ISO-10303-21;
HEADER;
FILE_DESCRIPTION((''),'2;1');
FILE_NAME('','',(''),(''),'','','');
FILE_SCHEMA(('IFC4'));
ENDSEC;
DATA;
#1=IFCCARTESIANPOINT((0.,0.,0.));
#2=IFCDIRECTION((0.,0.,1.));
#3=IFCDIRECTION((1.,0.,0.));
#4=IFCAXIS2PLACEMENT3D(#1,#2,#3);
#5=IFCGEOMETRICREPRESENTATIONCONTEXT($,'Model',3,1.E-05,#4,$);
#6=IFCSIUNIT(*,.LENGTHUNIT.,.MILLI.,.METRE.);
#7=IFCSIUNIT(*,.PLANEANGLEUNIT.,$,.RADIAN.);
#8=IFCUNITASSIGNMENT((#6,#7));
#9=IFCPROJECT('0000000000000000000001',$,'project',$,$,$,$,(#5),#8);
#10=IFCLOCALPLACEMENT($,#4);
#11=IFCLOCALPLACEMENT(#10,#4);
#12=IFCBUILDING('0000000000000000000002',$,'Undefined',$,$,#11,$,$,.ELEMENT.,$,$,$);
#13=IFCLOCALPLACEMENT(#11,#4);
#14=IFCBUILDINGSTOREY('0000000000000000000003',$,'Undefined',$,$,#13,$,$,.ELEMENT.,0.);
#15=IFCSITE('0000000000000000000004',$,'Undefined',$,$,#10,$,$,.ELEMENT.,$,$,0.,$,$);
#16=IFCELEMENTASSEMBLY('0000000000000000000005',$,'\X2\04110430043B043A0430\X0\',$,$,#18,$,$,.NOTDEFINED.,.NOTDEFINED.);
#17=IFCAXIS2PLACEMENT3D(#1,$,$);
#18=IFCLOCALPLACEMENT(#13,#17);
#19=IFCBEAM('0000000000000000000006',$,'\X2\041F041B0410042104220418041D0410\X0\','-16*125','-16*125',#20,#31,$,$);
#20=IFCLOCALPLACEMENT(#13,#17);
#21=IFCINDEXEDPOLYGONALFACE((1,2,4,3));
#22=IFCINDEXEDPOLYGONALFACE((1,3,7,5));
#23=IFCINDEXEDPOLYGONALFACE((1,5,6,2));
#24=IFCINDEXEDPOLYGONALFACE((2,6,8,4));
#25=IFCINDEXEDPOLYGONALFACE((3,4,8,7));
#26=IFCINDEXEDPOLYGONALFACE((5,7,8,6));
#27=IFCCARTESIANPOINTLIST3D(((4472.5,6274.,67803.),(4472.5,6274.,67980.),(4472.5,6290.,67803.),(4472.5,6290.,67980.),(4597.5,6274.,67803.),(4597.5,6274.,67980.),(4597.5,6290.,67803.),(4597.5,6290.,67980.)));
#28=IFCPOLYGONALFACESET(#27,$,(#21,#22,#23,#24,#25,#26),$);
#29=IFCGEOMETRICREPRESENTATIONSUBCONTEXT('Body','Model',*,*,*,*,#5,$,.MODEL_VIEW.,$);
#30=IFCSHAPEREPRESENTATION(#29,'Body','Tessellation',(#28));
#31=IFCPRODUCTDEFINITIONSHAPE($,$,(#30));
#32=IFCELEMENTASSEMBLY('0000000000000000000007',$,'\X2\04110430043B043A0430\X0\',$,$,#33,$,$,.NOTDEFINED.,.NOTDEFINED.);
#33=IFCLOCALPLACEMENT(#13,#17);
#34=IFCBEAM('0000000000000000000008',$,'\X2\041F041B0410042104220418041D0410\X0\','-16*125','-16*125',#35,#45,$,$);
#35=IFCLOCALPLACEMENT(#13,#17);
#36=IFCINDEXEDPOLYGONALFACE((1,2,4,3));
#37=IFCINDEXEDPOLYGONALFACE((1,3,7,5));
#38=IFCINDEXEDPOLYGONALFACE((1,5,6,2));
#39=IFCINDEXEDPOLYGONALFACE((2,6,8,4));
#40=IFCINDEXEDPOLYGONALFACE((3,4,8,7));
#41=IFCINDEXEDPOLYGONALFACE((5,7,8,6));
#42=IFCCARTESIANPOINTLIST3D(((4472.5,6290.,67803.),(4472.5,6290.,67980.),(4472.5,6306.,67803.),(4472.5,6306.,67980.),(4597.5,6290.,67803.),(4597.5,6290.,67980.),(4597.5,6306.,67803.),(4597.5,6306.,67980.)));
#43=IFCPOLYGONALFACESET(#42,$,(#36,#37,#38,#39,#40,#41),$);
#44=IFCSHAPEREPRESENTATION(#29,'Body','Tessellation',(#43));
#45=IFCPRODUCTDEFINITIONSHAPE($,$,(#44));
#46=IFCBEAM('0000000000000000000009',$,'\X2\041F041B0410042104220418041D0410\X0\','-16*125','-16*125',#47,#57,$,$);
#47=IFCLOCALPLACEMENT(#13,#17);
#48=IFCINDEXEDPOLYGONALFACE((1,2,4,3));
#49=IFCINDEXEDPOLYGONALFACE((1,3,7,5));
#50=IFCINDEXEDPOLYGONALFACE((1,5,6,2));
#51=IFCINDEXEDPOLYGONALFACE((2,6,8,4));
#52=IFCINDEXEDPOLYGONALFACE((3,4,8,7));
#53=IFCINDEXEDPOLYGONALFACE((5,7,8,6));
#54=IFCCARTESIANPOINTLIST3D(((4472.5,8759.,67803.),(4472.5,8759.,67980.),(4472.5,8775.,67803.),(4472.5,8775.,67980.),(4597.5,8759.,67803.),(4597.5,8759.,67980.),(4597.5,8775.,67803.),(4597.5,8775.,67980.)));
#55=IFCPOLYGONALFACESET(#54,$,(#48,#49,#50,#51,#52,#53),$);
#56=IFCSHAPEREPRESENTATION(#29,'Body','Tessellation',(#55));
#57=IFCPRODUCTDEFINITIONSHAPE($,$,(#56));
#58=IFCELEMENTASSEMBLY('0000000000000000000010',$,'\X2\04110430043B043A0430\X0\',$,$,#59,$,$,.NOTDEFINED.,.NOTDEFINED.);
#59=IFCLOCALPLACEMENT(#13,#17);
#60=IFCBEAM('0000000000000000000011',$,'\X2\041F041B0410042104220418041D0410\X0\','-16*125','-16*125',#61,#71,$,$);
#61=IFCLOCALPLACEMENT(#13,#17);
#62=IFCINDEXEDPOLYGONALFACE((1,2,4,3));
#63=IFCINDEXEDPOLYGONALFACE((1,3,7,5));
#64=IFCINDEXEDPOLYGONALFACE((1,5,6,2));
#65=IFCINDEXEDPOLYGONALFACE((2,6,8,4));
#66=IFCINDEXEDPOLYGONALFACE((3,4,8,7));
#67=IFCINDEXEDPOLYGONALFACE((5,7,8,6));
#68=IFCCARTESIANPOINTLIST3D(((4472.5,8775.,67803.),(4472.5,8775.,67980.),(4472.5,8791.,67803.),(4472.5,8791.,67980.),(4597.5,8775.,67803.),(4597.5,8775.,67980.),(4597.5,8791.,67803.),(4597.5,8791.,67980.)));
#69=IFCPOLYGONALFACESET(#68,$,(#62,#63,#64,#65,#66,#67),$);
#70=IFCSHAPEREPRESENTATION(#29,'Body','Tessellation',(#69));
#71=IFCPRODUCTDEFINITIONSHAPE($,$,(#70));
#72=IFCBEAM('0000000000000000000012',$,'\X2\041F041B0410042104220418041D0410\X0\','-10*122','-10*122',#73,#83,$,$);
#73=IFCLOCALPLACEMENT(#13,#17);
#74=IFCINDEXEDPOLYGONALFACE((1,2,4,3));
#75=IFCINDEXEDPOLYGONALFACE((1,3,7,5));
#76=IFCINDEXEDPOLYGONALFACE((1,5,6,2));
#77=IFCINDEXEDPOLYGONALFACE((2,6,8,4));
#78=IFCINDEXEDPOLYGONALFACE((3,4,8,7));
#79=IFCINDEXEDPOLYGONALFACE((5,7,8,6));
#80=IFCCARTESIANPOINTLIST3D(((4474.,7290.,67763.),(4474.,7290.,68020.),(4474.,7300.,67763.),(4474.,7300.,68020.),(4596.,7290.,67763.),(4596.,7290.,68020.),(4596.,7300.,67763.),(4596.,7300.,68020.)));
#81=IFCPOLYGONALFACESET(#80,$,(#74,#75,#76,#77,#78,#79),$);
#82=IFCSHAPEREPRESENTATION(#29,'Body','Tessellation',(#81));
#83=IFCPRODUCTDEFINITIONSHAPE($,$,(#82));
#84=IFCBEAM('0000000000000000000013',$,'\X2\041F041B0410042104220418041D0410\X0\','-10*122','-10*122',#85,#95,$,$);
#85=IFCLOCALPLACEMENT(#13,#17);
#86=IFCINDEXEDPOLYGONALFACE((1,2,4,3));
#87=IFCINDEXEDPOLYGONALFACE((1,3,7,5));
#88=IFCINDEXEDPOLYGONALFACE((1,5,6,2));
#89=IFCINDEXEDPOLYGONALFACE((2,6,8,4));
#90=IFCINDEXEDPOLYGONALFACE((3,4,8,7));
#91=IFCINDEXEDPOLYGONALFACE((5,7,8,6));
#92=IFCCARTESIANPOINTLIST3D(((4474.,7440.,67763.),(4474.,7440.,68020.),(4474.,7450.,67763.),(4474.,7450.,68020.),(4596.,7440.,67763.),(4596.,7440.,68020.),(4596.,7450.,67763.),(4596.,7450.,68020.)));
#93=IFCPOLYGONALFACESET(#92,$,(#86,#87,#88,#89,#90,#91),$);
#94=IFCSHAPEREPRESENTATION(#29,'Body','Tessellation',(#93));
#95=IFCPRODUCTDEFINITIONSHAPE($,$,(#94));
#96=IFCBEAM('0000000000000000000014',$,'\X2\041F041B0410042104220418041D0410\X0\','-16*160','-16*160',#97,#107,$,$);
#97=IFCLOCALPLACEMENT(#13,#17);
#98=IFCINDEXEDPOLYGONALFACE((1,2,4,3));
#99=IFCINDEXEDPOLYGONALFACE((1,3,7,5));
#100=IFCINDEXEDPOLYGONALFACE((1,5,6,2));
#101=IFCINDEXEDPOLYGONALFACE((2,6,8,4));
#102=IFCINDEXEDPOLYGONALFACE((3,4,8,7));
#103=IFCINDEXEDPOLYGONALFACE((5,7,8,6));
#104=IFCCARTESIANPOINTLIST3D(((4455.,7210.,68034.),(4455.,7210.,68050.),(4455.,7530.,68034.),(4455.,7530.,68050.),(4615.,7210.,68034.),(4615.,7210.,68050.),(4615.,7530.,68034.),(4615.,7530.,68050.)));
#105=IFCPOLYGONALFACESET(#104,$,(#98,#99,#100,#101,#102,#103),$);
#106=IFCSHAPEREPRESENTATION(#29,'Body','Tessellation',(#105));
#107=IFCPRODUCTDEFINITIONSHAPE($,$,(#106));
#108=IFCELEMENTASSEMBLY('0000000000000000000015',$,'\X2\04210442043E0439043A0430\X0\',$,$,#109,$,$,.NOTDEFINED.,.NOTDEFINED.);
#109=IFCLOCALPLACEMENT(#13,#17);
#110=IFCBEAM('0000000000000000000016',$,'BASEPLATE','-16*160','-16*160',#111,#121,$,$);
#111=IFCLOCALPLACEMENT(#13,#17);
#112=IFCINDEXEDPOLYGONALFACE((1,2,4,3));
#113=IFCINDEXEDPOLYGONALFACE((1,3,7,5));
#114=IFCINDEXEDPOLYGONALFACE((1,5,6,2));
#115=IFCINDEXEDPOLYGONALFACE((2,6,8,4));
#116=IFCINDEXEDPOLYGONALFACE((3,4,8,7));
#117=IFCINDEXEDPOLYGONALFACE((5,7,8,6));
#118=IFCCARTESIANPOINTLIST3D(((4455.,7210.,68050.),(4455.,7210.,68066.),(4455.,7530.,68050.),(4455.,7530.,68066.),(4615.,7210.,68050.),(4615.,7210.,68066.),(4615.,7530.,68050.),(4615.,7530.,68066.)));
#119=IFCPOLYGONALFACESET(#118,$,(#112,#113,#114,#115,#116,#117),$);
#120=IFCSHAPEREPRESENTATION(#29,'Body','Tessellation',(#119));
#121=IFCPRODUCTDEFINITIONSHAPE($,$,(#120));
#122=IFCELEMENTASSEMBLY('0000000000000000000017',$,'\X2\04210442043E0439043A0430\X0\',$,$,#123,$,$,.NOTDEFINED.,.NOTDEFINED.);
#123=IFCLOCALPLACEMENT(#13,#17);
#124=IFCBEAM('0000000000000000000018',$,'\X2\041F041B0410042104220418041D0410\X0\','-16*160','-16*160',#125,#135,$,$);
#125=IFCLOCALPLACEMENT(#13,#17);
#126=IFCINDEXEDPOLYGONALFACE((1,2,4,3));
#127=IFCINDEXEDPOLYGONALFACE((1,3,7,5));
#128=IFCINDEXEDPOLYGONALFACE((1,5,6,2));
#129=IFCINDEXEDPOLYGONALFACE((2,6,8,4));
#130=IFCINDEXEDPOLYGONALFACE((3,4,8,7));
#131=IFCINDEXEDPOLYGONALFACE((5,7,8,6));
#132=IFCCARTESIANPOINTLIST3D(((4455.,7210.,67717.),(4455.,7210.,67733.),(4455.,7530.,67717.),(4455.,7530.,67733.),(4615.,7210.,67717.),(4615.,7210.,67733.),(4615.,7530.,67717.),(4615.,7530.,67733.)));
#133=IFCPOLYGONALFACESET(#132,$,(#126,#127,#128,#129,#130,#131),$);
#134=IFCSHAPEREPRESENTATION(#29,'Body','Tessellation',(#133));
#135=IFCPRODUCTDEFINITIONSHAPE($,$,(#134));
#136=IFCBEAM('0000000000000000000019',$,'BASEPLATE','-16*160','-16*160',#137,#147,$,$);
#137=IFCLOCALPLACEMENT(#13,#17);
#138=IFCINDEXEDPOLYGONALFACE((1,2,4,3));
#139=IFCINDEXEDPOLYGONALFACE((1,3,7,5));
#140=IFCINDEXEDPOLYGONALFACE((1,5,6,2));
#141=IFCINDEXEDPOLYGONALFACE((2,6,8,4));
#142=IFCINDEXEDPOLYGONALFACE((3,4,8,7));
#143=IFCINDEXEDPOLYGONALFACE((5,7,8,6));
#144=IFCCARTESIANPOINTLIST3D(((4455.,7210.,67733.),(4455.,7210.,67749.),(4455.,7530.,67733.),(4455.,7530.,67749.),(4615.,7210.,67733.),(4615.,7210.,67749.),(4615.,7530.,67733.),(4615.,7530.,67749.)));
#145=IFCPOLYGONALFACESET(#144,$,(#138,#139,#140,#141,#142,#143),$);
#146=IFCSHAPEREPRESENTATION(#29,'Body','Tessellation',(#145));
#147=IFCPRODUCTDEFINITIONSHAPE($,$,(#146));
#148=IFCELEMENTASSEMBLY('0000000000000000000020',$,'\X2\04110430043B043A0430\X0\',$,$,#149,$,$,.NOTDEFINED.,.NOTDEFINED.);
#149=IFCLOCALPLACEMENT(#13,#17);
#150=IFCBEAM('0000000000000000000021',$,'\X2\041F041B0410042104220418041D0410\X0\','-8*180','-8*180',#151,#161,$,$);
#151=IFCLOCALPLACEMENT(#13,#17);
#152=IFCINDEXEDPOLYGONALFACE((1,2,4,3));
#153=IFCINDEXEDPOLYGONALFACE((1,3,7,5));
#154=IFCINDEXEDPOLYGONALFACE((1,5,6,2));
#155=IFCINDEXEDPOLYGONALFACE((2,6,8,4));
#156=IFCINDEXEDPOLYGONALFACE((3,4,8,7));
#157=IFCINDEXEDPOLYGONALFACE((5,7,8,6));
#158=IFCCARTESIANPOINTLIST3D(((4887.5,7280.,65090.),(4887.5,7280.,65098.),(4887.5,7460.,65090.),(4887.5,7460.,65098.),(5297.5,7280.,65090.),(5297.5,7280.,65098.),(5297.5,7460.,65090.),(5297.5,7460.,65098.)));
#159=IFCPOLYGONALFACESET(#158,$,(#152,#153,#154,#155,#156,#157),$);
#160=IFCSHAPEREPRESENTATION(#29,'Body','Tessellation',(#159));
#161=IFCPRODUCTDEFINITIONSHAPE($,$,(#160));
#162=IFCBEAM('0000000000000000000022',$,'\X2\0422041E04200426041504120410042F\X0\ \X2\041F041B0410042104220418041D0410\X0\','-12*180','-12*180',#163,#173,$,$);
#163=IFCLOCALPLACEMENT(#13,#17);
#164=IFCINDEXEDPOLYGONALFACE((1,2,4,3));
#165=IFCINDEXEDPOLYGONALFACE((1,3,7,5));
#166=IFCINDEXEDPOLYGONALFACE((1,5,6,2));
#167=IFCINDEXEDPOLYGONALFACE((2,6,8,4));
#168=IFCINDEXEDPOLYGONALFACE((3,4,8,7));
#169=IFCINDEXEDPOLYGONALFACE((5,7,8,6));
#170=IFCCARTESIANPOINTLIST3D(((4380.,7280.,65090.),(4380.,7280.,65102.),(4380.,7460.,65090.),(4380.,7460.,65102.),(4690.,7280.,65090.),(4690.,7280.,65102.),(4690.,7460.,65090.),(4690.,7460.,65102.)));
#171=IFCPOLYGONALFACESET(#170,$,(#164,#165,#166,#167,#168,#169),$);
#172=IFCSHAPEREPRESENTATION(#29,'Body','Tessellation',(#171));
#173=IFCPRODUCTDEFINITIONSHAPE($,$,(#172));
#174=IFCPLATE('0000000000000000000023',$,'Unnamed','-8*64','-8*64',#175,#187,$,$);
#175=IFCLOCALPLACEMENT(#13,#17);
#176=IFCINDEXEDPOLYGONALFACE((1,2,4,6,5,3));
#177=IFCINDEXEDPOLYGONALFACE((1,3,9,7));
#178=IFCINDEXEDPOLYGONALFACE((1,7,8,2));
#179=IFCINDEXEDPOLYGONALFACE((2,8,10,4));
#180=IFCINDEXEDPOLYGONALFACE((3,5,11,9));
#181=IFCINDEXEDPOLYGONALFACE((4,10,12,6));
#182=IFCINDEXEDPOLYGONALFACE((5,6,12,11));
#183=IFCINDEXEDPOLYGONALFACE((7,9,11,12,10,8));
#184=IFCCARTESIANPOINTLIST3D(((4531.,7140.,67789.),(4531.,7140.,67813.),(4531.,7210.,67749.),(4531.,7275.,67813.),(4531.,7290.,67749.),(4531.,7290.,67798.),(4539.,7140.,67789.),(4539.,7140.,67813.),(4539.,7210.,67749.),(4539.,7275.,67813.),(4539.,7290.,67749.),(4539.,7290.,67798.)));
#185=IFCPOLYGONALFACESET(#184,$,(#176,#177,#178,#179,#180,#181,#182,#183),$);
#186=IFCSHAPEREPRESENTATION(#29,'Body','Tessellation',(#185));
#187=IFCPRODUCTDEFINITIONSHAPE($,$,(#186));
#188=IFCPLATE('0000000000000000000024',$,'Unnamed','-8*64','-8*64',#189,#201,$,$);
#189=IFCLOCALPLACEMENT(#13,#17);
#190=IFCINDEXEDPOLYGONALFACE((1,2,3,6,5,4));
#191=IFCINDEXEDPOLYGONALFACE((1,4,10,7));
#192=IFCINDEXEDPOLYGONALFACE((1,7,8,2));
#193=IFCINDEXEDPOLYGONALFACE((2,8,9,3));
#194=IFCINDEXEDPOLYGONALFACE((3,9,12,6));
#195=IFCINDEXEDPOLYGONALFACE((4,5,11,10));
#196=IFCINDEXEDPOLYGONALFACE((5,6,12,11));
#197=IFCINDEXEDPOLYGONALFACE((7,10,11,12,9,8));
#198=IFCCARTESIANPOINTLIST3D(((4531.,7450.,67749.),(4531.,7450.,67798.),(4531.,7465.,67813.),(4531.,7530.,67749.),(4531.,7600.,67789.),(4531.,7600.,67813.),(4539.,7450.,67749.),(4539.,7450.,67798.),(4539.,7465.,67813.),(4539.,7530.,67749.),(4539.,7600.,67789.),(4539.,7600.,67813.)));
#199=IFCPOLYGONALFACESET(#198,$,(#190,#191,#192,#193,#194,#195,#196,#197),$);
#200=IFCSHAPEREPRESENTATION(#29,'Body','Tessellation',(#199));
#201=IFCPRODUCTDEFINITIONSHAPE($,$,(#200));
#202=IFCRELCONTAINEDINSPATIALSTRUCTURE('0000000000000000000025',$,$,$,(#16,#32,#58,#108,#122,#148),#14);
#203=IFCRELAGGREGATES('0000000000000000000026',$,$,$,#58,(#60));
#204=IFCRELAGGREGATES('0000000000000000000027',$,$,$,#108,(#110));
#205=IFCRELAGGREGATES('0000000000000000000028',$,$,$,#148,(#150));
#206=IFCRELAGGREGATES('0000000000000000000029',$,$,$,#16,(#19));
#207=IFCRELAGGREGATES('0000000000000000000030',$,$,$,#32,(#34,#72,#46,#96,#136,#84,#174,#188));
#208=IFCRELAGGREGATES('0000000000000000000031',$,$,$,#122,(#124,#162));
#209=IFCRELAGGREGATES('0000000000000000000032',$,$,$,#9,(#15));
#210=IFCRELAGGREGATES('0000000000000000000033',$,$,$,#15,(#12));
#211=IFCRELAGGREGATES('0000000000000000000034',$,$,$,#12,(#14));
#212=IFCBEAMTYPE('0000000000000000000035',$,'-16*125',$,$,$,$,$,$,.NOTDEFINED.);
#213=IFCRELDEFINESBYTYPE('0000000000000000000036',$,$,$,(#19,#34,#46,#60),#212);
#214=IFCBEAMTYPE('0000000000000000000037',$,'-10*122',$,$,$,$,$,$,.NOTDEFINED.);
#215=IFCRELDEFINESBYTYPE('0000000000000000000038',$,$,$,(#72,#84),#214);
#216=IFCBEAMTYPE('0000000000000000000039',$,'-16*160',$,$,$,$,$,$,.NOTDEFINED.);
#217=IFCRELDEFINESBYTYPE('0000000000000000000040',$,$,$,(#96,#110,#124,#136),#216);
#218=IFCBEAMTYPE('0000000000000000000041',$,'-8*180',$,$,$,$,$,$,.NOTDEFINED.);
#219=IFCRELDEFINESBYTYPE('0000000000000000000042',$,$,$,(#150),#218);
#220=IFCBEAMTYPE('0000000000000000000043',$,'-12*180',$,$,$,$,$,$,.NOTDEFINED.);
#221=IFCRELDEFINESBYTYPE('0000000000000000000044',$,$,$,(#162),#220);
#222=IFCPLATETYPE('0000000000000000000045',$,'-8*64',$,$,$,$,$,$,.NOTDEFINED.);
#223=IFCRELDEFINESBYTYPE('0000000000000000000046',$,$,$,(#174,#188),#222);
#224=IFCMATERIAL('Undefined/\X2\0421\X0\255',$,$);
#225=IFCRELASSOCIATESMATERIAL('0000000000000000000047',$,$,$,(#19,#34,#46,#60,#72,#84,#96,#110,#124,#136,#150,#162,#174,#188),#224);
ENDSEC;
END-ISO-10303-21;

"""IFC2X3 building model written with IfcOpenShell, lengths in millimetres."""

from ifc_helpers import new_model, si_unit, frame, origin_with_axes, origin_2d_with_axis, place, context, subcontext, project, spatial, polyline, rectangle, outline, extrude, material, type_object, element, aggregate, save


model = new_model("IFC2X3")

# Units and contexts
model_context = context("Model", 3, precision=1e-05, world=origin_with_axes())
body_context = subcontext(model_context, "Body", "Model", "MODEL_VIEW")
ifc_project = project(units=[si_unit("LENGTHUNIT", "METRE", prefix="MILLI"), si_unit("PLANEANGLEUNIT", "RADIAN")], contexts=[model_context])

# Site, building, storey
site_placement = place(None, origin_with_axes())
site = spatial("IfcSite", under=ifc_project, at=site_placement, Name="Undefined", CompositionType="ELEMENT", RefElevation=0.0)
building_placement = place(site_placement, origin_with_axes())
building = spatial("IfcBuilding", under=site, at=building_placement, Name="Undefined", CompositionType="ELEMENT")
storey_placement = place(building_placement, origin_with_axes())
storey = spatial("IfcBuildingStorey", under=building, at=storey_placement, Name="Undefined", CompositionType="ELEMENT", Elevation=0.0)

# Element assembly, beam
assembly_1_placement = place(storey_placement, origin_with_axes())
assembly_1 = element("IfcElementAssembly", 1, at=assembly_1_placement, inside=storey, Name="Балка", AssemblyPlace="NOTDEFINED", PredefinedType="NOTDEFINED")
ifc_material_1 = material(Name="Undefined/С255")
beam_type_1 = type_object("IfcBeamType", Name="-16*125", PredefinedType="NOTDEFINED")
beam_1_placement = place(assembly_1_placement, frame((4535.0, 6282.0, 67803.0), z_axis=(-1.0, 0.0, 0.0), x_axis=(0.0, 0.0, 1.0)))
beam_1 = element("IfcBeam", 2, at=beam_1_placement, type_object=beam_type_1, material=ifc_material_1, Name="ПЛАСТИНА", Description="-16*125", ObjectType="-16*125", context=body_context, shape_type="SweptSolid", body=[
    extrude(rectangle(XDim=16.0, YDim=125.0, at=origin_2d_with_axis()), frame((177.0, 0.0, 0.0), z_axis=(-1.0, 0.0, 0.0), x_axis=(0.0, -1.0, 0.0)), (0.0, 0.0, 1.0), 177.0),
])

# Element assembly, beams
assembly_2_placement = place(storey_placement, origin_with_axes())
assembly_2 = element("IfcElementAssembly", 3, at=assembly_2_placement, inside=storey, Name="Балка", AssemblyPlace="NOTDEFINED", PredefinedType="NOTDEFINED")
beam_2_placement = place(assembly_2_placement, frame((4535.0, 6298.0, 67803.0), z_axis=(-1.0, 0.0, 0.0), x_axis=(0.0, 0.0, 1.0)))
beam_2 = element("IfcBeam", 4, at=beam_2_placement, type_object=beam_type_1, material=ifc_material_1, Name="ПЛАСТИНА", Description="-16*125", ObjectType="-16*125", context=body_context, shape_type="SweptSolid", body=[
    extrude(rectangle(XDim=16.0, YDim=125.0, at=origin_2d_with_axis()), frame((177.0, 0.0, 0.0), z_axis=(-1.0, 0.0, 0.0), x_axis=(0.0, -1.0, 0.0)), (0.0, 0.0, 1.0), 177.0),
])
beam_3_placement = place(assembly_2_placement, frame((4535.0, 8767.0, 67803.0), z_axis=(-1.0, 0.0, 0.0), x_axis=(0.0, 0.0, 1.0)))
beam_3 = element("IfcBeam", 5, at=beam_3_placement, type_object=beam_type_1, material=ifc_material_1, Name="ПЛАСТИНА", Description="-16*125", ObjectType="-16*125", context=body_context, shape_type="SweptSolid", body=[
    extrude(rectangle(XDim=16.0, YDim=125.0, at=origin_2d_with_axis()), frame((177.0, 0.0, 0.0), z_axis=(-1.0, 0.0, 0.0), x_axis=(0.0, -1.0, 0.0)), (0.0, 0.0, 1.0), 177.0),
])

# Element assembly, beam
assembly_3_placement = place(storey_placement, origin_with_axes())
assembly_3 = element("IfcElementAssembly", 6, at=assembly_3_placement, inside=storey, Name="Балка", AssemblyPlace="NOTDEFINED", PredefinedType="NOTDEFINED")
beam_4_placement = place(assembly_3_placement, frame((4535.0, 8783.0, 67803.0), z_axis=(-1.0, 0.0, 0.0), x_axis=(0.0, 0.0, 1.0)))
beam_4 = element("IfcBeam", 7, at=beam_4_placement, type_object=beam_type_1, material=ifc_material_1, Name="ПЛАСТИНА", Description="-16*125", ObjectType="-16*125", context=body_context, shape_type="SweptSolid", body=[
    extrude(rectangle(XDim=16.0, YDim=125.0, at=origin_2d_with_axis()), frame((177.0, 0.0, 0.0), z_axis=(-1.0, 0.0, 0.0), x_axis=(0.0, -1.0, 0.0)), (0.0, 0.0, 1.0), 177.0),
])
aggregate(assembly_3, [beam_4])

# Beams
beam_type_2 = type_object("IfcBeamType", Name="-10*122", PredefinedType="NOTDEFINED")
beam_5_placement = place(assembly_2_placement, frame((4535.0, 7295.0, 67763.0), z_axis=(-1.0, 0.0, 0.0), x_axis=(0.0, 0.0, 1.0)))
beam_5 = element("IfcBeam", 8, at=beam_5_placement, type_object=beam_type_2, material=ifc_material_1, Name="ПЛАСТИНА", Description="-10*122", ObjectType="-10*122", context=body_context, shape_type="SweptSolid", body=[
    extrude(rectangle(XDim=10.0, YDim=122.0, at=origin_2d_with_axis()), frame((257.0, 0.0, 0.0), z_axis=(-1.0, 0.0, 0.0), x_axis=(0.0, -1.0, 0.0)), (0.0, 0.0, 1.0), 257.0),
])
beam_6_placement = place(assembly_2_placement, frame((4535.0, 7445.0, 67763.0), z_axis=(1.0, 0.0, 0.0), x_axis=(0.0, 0.0, 1.0)))
beam_6 = element("IfcBeam", 9, at=beam_6_placement, type_object=beam_type_2, material=ifc_material_1, Name="ПЛАСТИНА", Description="-10*122", ObjectType="-10*122", context=body_context, shape_type="SweptSolid", body=[
    extrude(rectangle(XDim=10.0, YDim=122.0, at=origin_2d_with_axis()), frame((257.0, 0.0, 0.0), z_axis=(-1.0, 0.0, 0.0), x_axis=(0.0, -1.0, 0.0)), (0.0, 0.0, 1.0), 257.0),
])
beam_type_3 = type_object("IfcBeamType", Name="-16*160", PredefinedType="NOTDEFINED")
beam_7_placement = place(assembly_2_placement, frame((4535.0, 7530.0, 68042.0), z_axis=(1.0, 0.0, -0.000008), x_axis=(0.0, -1.0, 0.0)))
beam_7 = element("IfcBeam", 10, at=beam_7_placement, type_object=beam_type_3, material=ifc_material_1, Name="ПЛАСТИНА", Description="-16*160", ObjectType="-16*160", context=body_context, shape_type="SweptSolid", body=[
    extrude(rectangle(XDim=16.0, YDim=160.0, at=origin_2d_with_axis()), frame((320.0, 0.0, 0.0), z_axis=(-1.0, 0.0, 0.0), x_axis=(0.0, -1.0, 0.0)), (0.0, 0.0, 1.0), 320.0),
])

# Element assemblies, beams
assembly_4_placement = place(storey_placement, origin_with_axes())
assembly_4 = element("IfcElementAssembly", 11, at=assembly_4_placement, inside=storey, Name="Стойка", AssemblyPlace="NOTDEFINED", PredefinedType="NOTDEFINED")
beam_8_placement = place(assembly_4_placement, frame((4535.0, 7530.0, 68058.0), z_axis=(1.0, 0.0, -0.000008), x_axis=(0.0, -1.0, 0.0)))
beam_8 = element("IfcBeam", 12, at=beam_8_placement, type_object=beam_type_3, material=ifc_material_1, Name="BASEPLATE", Description="-16*160", ObjectType="-16*160", context=body_context, shape_type="SweptSolid", body=[
    extrude(rectangle(XDim=16.0, YDim=160.0, at=origin_2d_with_axis()), frame((320.0, 0.0, 0.0), z_axis=(-1.0, 0.0, 0.0), x_axis=(0.0, -1.0, 0.0)), (0.0, 0.0, 1.0), 320.0),
])
aggregate(assembly_4, [beam_8])
assembly_5_placement = place(storey_placement, origin_with_axes())
assembly_5 = element("IfcElementAssembly", 13, at=assembly_5_placement, inside=storey, Name="Стойка", AssemblyPlace="NOTDEFINED", PredefinedType="NOTDEFINED")
beam_9_placement = place(assembly_5_placement, frame((4535.0, 7530.0, 67725.0), z_axis=(1.0, 0.0, -0.000008), x_axis=(0.0, -1.0, 0.0)))
beam_9 = element("IfcBeam", 14, at=beam_9_placement, type_object=beam_type_3, material=ifc_material_1, Name="ПЛАСТИНА", Description="-16*160", ObjectType="-16*160", context=body_context, shape_type="SweptSolid", body=[
    extrude(rectangle(XDim=16.0, YDim=160.0, at=origin_2d_with_axis()), frame((320.0, 0.0, 0.0), z_axis=(-1.0, 0.0, 0.0), x_axis=(0.0, -1.0, 0.0)), (0.0, 0.0, 1.0), 320.0),
])

# Beam
beam_10_placement = place(assembly_2_placement, frame((4535.0, 7530.0, 67741.0), z_axis=(1.0, 0.0, -0.000008), x_axis=(0.0, -1.0, 0.0)))
beam_10 = element("IfcBeam", 15, at=beam_10_placement, type_object=beam_type_3, material=ifc_material_1, Name="BASEPLATE", Description="-16*160", ObjectType="-16*160", context=body_context, shape_type="SweptSolid", body=[
    extrude(rectangle(XDim=16.0, YDim=160.0, at=origin_2d_with_axis()), frame((320.0, 0.0, 0.0), z_axis=(-1.0, 0.0, 0.0), x_axis=(0.0, -1.0, 0.0)), (0.0, 0.0, 1.0), 320.0),
])

# Element assembly, beam
assembly_6_placement = place(storey_placement, origin_with_axes())
assembly_6 = element("IfcElementAssembly", 16, at=assembly_6_placement, inside=storey, Name="Балка", AssemblyPlace="NOTDEFINED", PredefinedType="NOTDEFINED")
beam_type_4 = type_object("IfcBeamType", Name="-8*180", PredefinedType="NOTDEFINED")
beam_11_placement = place(assembly_6_placement, frame((4887.5, 7370.0, 65094.0), z_axis=(0.0, -1.0, 0.0), x_axis=(1.0, 0.0, 0.0)))
beam_11 = element("IfcBeam", 17, at=beam_11_placement, type_object=beam_type_4, material=ifc_material_1, Name="ПЛАСТИНА", Description="-8*180", ObjectType="-8*180", context=body_context, shape_type="SweptSolid", body=[
    extrude(rectangle(XDim=8.0, YDim=180.0, at=origin_2d_with_axis()), frame((410.0, 0.0, 0.0), z_axis=(-1.0, 0.0, 0.0), x_axis=(0.0, -1.0, 0.0)), (0.0, 0.0, 1.0), 410.0),
])
aggregate(assembly_6, [beam_11])

# Beam
beam_type_5 = type_object("IfcBeamType", Name="-12*180", PredefinedType="NOTDEFINED")
beam_12_placement = place(assembly_5_placement, frame((4380.0, 7370.0, 65096.0), z_axis=(0.0, 1.0, 0.0), x_axis=(1.0, 0.0, 0.0)))
beam_12 = element("IfcBeam", 18, at=beam_12_placement, type_object=beam_type_5, material=ifc_material_1, Name="ТОРЦЕВАЯ ПЛАСТИНА", Description="-12*180", ObjectType="-12*180", context=body_context, shape_type="SweptSolid", body=[
    extrude(rectangle(XDim=12.0, YDim=180.0, at=origin_2d_with_axis()), frame((310.0, 0.0, 0.0), z_axis=(-1.0, 0.0, 0.0), x_axis=(0.0, -1.0, 0.0)), (0.0, 0.0, 1.0), 310.0),
])

# Plates
plate_type = type_object("IfcPlateType", Name="-8*64", PredefinedType="NOTDEFINED")
plate_1_placement = place(assembly_2_placement, frame((4535.0, 7140.0, 67813.0), z_axis=(-1.0, 0.0, 0.0), x_axis=(0.0, 1.0, 0.0)))
plate_1 = element("IfcPlate", 19, at=plate_1_placement, type_object=plate_type, material=ifc_material_1, Name="Unnamed", Description="-8*64", ObjectType="-8*64", context=body_context, shape_type="SweptSolid", body=[
    extrude(outline(polyline([(0.0, 0.0), (135.0, 0.0), (150.0, 15.0), (150.0, 64.0), (70.0, 64.0), (0.0, 24.0), (0.0, 0.0)])), frame((0.0, 0.0, -4.0), z_axis=(0.0, 0.0, 1.0), x_axis=(1.0, 0.0, 0.0)), (0.0, 0.0, 1.0), 8.0),
])
plate_2_placement = place(assembly_2_placement, frame((4535.0, 7600.0, 67813.0), z_axis=(1.0, 0.0, 0.0), x_axis=(0.0, -1.0, 0.0)))
plate_2 = element("IfcPlate", 20, at=plate_2_placement, type_object=plate_type, material=ifc_material_1, Name="Unnamed", Description="-8*64", ObjectType="-8*64", context=body_context, shape_type="SweptSolid", body=[
    extrude(outline(polyline([(0.0, 0.0), (135.0, 0.0), (150.0, 15.0), (150.0, 64.0), (70.0, 64.0), (0.0, 24.0), (0.0, 0.0)])), frame((0.0, 0.0, -4.0), z_axis=(0.0, 0.0, 1.0), x_axis=(1.0, 0.0, 0.0)), (0.0, 0.0, 1.0), 8.0),
])

aggregate(assembly_1, [beam_1])
aggregate(assembly_2, [beam_2, beam_5, beam_3, beam_7, beam_10, beam_6, plate_1, plate_2])
aggregate(assembly_5, [beam_9, beam_12])

save(model, "model.ifc")
